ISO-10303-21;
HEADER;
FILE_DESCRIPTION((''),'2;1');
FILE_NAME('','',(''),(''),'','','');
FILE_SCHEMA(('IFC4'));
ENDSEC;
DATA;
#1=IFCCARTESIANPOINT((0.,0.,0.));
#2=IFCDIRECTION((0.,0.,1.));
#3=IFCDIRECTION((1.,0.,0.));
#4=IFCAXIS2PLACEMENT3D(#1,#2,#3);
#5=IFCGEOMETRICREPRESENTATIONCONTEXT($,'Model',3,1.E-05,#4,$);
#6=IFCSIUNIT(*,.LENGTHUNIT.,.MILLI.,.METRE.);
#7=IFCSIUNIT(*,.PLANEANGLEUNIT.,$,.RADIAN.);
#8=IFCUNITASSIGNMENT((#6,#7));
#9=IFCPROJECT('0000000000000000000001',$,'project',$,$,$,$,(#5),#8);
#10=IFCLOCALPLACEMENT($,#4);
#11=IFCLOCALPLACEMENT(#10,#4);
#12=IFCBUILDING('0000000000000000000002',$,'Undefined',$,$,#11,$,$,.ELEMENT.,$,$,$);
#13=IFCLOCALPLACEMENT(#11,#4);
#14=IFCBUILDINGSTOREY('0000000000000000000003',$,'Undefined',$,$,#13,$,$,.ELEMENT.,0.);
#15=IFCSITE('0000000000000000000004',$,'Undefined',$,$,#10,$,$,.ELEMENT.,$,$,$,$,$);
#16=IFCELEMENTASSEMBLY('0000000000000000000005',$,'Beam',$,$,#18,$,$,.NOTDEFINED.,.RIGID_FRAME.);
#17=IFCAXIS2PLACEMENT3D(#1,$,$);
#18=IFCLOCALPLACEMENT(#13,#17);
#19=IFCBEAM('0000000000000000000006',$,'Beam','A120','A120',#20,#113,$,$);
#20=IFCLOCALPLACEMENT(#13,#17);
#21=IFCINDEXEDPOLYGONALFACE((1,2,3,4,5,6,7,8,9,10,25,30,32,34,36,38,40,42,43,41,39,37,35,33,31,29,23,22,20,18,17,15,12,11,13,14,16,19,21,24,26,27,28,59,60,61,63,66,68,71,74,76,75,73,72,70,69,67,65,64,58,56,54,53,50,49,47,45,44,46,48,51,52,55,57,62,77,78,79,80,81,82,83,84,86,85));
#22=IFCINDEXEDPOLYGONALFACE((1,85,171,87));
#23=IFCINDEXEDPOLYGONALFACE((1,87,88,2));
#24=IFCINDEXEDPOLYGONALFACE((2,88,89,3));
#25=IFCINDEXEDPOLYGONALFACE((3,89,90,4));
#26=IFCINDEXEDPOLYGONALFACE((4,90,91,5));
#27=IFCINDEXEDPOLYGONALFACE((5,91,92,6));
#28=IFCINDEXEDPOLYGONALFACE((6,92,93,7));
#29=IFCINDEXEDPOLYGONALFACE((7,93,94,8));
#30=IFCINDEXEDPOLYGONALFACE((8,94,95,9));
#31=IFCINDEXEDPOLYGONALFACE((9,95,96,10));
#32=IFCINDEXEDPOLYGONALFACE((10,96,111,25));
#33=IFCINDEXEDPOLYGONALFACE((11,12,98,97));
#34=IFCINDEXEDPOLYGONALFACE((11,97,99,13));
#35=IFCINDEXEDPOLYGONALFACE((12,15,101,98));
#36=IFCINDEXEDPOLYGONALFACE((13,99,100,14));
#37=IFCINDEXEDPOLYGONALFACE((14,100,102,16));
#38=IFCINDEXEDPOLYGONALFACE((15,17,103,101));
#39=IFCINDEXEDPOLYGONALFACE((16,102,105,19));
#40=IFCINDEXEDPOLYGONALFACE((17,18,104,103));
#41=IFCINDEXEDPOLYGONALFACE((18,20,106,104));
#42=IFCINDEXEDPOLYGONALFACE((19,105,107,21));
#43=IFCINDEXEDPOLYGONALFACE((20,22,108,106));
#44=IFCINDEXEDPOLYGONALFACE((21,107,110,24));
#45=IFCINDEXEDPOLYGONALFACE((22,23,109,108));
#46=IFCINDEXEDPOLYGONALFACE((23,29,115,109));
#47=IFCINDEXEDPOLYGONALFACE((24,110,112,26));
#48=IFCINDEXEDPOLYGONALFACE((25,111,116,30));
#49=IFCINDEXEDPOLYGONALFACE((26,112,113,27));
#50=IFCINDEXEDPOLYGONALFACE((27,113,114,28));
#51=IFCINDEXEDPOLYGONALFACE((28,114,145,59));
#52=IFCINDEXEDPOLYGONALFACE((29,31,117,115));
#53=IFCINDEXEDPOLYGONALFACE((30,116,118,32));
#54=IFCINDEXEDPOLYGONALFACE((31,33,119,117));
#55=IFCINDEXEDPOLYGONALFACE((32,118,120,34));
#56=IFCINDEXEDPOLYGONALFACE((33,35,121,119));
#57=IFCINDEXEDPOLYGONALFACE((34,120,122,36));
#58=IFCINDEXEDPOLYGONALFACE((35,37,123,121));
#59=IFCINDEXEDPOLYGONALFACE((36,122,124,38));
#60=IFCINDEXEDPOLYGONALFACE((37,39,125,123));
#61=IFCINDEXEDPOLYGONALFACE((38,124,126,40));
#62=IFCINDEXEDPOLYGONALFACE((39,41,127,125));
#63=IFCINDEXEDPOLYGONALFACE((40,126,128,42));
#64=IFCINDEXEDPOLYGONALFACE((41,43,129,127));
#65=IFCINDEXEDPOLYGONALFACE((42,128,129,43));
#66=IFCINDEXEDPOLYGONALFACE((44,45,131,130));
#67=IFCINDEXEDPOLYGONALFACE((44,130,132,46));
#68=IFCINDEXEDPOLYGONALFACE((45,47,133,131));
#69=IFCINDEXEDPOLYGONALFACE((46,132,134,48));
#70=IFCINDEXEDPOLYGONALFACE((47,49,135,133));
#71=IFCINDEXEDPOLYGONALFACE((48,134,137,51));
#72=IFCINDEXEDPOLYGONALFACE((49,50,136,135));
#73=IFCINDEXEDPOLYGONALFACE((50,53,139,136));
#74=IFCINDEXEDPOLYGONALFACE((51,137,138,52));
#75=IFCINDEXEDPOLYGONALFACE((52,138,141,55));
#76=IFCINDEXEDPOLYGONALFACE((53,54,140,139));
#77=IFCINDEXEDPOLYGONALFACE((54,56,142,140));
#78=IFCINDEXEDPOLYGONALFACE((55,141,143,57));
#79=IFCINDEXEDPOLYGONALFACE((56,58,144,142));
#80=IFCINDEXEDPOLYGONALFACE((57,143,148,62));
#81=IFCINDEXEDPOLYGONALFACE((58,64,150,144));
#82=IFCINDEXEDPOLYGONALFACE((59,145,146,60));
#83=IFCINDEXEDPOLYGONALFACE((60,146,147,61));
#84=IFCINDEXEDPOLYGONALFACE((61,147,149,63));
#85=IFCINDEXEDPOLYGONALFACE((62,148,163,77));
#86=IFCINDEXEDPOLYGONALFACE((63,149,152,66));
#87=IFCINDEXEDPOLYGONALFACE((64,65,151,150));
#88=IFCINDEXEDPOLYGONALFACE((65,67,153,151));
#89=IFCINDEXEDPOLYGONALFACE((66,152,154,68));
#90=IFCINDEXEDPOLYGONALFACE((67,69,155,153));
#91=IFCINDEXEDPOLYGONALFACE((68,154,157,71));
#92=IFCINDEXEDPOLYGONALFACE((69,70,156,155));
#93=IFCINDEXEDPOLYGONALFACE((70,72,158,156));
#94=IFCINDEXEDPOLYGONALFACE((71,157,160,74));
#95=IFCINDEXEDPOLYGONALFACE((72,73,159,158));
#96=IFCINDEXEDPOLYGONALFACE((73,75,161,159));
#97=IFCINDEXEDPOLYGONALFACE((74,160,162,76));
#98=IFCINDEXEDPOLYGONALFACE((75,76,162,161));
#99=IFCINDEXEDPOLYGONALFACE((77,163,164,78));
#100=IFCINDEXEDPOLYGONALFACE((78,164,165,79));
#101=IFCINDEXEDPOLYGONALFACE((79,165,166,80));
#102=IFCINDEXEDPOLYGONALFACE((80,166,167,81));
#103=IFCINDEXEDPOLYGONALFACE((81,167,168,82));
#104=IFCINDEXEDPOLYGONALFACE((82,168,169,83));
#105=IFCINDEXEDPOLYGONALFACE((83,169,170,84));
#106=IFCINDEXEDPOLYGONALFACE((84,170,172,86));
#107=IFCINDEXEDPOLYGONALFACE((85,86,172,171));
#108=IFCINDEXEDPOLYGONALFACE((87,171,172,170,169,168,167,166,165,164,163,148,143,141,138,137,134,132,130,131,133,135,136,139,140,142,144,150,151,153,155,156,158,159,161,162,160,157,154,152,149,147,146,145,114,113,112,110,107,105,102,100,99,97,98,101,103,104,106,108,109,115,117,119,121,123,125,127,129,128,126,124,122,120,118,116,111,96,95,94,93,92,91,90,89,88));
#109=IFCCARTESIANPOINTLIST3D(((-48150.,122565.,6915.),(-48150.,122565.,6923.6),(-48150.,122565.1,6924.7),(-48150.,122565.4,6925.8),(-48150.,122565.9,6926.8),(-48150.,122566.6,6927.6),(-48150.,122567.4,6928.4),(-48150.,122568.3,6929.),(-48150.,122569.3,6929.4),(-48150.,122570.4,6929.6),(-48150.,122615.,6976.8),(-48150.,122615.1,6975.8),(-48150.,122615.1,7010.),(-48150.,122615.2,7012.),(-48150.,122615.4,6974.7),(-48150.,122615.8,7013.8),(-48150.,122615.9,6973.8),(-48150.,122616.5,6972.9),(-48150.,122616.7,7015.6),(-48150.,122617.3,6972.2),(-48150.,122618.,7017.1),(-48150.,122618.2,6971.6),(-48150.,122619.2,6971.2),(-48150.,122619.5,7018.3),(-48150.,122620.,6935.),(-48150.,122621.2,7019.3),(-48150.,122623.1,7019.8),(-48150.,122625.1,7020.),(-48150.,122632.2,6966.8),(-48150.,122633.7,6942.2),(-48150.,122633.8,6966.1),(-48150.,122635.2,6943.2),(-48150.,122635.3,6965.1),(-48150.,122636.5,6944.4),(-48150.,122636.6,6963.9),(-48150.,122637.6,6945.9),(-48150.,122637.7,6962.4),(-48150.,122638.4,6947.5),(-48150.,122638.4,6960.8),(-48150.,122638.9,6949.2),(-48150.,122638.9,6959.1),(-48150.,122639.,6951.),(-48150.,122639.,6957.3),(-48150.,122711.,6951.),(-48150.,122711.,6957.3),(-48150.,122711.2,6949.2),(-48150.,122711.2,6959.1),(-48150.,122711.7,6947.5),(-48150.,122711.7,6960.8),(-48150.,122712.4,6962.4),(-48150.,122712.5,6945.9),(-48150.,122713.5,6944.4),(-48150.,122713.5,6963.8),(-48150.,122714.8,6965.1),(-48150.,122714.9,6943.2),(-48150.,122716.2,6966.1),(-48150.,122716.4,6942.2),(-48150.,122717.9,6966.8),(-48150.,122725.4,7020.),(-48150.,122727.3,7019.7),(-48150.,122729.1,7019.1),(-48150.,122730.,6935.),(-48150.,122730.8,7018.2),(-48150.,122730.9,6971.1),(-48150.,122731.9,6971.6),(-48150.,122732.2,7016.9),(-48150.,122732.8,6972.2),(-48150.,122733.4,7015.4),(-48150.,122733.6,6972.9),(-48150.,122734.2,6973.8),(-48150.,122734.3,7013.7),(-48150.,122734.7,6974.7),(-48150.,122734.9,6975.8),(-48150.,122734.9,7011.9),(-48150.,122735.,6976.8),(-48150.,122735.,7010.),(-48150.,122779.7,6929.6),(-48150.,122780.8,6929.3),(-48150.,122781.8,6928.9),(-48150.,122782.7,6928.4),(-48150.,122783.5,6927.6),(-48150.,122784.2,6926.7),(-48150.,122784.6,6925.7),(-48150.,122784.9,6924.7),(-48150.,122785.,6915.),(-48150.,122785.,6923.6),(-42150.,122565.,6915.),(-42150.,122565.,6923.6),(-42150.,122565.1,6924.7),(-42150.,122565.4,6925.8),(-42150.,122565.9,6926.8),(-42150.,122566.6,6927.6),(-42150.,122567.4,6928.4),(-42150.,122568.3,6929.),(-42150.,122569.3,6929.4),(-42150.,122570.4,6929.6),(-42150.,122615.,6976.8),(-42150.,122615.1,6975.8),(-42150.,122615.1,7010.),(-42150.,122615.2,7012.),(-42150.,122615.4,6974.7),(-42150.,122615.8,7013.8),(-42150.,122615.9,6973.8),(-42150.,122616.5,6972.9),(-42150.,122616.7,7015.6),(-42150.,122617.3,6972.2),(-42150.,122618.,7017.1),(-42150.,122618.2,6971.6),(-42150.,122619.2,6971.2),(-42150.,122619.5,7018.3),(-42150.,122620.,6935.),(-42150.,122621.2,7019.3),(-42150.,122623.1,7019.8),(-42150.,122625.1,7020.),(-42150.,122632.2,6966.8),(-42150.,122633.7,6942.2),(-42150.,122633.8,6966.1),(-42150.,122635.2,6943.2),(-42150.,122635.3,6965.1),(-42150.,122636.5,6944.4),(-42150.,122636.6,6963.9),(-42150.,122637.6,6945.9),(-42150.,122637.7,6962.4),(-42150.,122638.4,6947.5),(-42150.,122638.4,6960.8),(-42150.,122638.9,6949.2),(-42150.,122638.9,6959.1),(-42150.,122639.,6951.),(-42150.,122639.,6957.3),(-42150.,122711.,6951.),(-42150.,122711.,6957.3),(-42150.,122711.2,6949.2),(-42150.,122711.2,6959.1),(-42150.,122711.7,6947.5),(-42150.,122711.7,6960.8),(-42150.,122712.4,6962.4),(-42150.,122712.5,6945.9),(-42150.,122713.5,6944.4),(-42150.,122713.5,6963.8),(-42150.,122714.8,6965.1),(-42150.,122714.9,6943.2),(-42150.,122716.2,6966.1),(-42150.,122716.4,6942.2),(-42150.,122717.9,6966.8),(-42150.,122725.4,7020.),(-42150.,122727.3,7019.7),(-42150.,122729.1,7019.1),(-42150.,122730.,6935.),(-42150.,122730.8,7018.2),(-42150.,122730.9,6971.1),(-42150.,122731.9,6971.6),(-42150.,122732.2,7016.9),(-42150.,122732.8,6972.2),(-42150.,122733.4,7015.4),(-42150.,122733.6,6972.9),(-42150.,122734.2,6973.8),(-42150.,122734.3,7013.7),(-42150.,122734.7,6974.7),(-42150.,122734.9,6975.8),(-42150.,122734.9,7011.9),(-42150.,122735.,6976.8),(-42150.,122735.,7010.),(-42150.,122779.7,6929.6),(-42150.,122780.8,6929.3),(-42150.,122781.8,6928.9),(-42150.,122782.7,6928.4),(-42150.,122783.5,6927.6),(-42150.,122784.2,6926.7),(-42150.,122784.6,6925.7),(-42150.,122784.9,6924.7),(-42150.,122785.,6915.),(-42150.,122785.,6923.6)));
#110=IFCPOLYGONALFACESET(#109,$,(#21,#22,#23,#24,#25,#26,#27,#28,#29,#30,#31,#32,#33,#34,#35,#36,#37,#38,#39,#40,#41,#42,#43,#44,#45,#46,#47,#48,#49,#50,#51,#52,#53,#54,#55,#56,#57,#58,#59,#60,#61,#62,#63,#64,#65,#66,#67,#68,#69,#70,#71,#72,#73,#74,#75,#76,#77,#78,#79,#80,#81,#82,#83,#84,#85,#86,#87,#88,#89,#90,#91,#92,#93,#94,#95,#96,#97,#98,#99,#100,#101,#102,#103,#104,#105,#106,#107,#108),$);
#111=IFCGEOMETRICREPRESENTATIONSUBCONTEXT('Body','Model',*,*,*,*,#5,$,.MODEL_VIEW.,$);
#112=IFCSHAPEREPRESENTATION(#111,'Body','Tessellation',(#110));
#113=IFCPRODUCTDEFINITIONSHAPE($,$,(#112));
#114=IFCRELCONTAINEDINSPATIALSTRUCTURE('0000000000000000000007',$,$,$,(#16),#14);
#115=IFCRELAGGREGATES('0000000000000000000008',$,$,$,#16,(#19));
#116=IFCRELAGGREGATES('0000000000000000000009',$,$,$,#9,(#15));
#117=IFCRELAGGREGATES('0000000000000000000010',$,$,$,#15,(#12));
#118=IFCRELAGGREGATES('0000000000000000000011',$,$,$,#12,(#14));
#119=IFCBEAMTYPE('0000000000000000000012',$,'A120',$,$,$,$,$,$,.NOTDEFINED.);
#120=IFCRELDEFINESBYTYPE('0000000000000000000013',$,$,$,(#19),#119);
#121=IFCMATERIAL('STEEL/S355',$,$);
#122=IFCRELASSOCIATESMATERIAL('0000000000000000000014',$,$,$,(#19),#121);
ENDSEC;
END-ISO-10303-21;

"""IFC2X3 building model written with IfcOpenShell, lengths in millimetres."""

from ifc_helpers import new_model, si_unit, frame, origin_with_axes, place, context, subcontext, project, spatial, polyline, outline, extrude, material, type_object, element, aggregate, save


model = new_model("IFC2X3")

# Units and contexts
model_context = context("Model", 3, precision=1e-05, world=origin_with_axes())
body_context = subcontext(model_context, "Body", "Model", "MODEL_VIEW")
ifc_project = project(units=[si_unit("LENGTHUNIT", "METRE", prefix="MILLI"), si_unit("PLANEANGLEUNIT", "RADIAN")], contexts=[model_context])

# Site, building, storey
site_placement = place(None, origin_with_axes())
site = spatial("IfcSite", under=ifc_project, at=site_placement, Name="Undefined", CompositionType="ELEMENT")
building_placement = place(site_placement, origin_with_axes())
building = spatial("IfcBuilding", under=site, at=building_placement, Name="Undefined", CompositionType="ELEMENT")
storey_placement = place(building_placement, origin_with_axes())
storey = spatial("IfcBuildingStorey", under=building, at=storey_placement, Name="Undefined", CompositionType="ELEMENT", Elevation=0.0)

# Element assembly, beam
ifc_material_1 = material(Name="STEEL/S355")
beam_type_1 = type_object("IfcBeamType", Name="A120", PredefinedType="NOTDEFINED")
assembly_1_placement = place(storey_placement, origin_with_axes())
assembly_1 = element("IfcElementAssembly", 1, at=assembly_1_placement, inside=storey, Name="Beam", AssemblyPlace="NOTDEFINED", PredefinedType="RIGID_FRAME")
beam_1_placement = place(assembly_1_placement, frame((-48150.0, 122675.0, 6967.5), z_axis=(0.0, 0.000118, 1.0), x_axis=(1.0, 0.0, 0.0)))
beam_1 = element("IfcBeam", 2, at=beam_1_placement, type_object=beam_type_1, material=ifc_material_1, Name="Beam", Description="A120", ObjectType="A120", context=body_context, shape_type="SweptSolid", body=[
    extrude(outline(polyline([(-110.0, -52.5), (-110.0, -43.9), (-109.9, -42.8), (-109.6, -41.8), (-109.1, -40.8), (-108.5, -39.9), (-107.7, -39.1), (-106.7, -38.6), (-105.7, -38.2), (-104.7, -37.9), (-55.0, -32.5), (-41.3, -25.3), (-39.8, -24.3), (-38.5, -23.1), (-37.4, -21.6), (-36.6, -20.0), (-36.2, -18.3), (-36.0, -16.5), (-36.0, -10.2), (-36.1, -8.4), (-36.6, -6.7), (-37.4, -5.1), (-38.4, -3.7), (-39.7, -2.4), (-41.2, -1.4), (-42.8, -0.7), (-55.9, 3.6), (-56.9, 4.1), (-57.8, 4.7), (-58.5, 5.4), (-59.2, 6.3), (-59.6, 7.2), (-59.9, 8.3), (-60.0, 9.3), (-60.0, 42.5), (-59.8, 44.4), (-59.3, 46.2), (-58.4, 47.9), (-57.2, 49.4), (-55.7, 50.7), (-54.1, 51.6), (-52.3, 52.2), (-50.4, 52.5), (50.0, 52.5), (51.9, 52.3), (53.8, 51.7), (55.5, 50.8), (57.1, 49.6), (58.3, 48.1), (59.2, 46.3), (59.8, 44.4), (60.0, 42.5), (60.0, 9.3), (59.9, 8.3), (59.6, 7.2), (59.2, 6.3), (58.5, 5.4), (57.8, 4.7), (56.9, 4.1), (55.9, 3.6), (42.8, -0.7), (41.2, -1.4), (39.7, -2.4), (38.4, -3.7), (37.4, -5.1), (36.6, -6.7), (36.1, -8.4), (36.0, -10.2), (36.0, -16.5), (36.2, -18.3), (36.6, -20.0), (37.4, -21.6), (38.5, -23.1), (39.8, -24.3), (41.3, -25.3), (55.0, -32.5), (104.7, -37.9), (105.7, -38.2), (106.7, -38.6), (107.7, -39.1), (108.5, -39.9), (109.1, -40.8), (109.6, -41.8), (109.9, -42.8), (110.0, -43.9), (110.0, -52.5), (-110.0, -52.5)])), frame((6000.0, 0.0, 0.0), z_axis=(-1.0, 0.0, 0.0), x_axis=(0.0, -1.0, 0.0)), (0.0, 0.0, 1.0), 6000.0),
])
aggregate(assembly_1, [beam_1])

save(model, "model.ifc")
